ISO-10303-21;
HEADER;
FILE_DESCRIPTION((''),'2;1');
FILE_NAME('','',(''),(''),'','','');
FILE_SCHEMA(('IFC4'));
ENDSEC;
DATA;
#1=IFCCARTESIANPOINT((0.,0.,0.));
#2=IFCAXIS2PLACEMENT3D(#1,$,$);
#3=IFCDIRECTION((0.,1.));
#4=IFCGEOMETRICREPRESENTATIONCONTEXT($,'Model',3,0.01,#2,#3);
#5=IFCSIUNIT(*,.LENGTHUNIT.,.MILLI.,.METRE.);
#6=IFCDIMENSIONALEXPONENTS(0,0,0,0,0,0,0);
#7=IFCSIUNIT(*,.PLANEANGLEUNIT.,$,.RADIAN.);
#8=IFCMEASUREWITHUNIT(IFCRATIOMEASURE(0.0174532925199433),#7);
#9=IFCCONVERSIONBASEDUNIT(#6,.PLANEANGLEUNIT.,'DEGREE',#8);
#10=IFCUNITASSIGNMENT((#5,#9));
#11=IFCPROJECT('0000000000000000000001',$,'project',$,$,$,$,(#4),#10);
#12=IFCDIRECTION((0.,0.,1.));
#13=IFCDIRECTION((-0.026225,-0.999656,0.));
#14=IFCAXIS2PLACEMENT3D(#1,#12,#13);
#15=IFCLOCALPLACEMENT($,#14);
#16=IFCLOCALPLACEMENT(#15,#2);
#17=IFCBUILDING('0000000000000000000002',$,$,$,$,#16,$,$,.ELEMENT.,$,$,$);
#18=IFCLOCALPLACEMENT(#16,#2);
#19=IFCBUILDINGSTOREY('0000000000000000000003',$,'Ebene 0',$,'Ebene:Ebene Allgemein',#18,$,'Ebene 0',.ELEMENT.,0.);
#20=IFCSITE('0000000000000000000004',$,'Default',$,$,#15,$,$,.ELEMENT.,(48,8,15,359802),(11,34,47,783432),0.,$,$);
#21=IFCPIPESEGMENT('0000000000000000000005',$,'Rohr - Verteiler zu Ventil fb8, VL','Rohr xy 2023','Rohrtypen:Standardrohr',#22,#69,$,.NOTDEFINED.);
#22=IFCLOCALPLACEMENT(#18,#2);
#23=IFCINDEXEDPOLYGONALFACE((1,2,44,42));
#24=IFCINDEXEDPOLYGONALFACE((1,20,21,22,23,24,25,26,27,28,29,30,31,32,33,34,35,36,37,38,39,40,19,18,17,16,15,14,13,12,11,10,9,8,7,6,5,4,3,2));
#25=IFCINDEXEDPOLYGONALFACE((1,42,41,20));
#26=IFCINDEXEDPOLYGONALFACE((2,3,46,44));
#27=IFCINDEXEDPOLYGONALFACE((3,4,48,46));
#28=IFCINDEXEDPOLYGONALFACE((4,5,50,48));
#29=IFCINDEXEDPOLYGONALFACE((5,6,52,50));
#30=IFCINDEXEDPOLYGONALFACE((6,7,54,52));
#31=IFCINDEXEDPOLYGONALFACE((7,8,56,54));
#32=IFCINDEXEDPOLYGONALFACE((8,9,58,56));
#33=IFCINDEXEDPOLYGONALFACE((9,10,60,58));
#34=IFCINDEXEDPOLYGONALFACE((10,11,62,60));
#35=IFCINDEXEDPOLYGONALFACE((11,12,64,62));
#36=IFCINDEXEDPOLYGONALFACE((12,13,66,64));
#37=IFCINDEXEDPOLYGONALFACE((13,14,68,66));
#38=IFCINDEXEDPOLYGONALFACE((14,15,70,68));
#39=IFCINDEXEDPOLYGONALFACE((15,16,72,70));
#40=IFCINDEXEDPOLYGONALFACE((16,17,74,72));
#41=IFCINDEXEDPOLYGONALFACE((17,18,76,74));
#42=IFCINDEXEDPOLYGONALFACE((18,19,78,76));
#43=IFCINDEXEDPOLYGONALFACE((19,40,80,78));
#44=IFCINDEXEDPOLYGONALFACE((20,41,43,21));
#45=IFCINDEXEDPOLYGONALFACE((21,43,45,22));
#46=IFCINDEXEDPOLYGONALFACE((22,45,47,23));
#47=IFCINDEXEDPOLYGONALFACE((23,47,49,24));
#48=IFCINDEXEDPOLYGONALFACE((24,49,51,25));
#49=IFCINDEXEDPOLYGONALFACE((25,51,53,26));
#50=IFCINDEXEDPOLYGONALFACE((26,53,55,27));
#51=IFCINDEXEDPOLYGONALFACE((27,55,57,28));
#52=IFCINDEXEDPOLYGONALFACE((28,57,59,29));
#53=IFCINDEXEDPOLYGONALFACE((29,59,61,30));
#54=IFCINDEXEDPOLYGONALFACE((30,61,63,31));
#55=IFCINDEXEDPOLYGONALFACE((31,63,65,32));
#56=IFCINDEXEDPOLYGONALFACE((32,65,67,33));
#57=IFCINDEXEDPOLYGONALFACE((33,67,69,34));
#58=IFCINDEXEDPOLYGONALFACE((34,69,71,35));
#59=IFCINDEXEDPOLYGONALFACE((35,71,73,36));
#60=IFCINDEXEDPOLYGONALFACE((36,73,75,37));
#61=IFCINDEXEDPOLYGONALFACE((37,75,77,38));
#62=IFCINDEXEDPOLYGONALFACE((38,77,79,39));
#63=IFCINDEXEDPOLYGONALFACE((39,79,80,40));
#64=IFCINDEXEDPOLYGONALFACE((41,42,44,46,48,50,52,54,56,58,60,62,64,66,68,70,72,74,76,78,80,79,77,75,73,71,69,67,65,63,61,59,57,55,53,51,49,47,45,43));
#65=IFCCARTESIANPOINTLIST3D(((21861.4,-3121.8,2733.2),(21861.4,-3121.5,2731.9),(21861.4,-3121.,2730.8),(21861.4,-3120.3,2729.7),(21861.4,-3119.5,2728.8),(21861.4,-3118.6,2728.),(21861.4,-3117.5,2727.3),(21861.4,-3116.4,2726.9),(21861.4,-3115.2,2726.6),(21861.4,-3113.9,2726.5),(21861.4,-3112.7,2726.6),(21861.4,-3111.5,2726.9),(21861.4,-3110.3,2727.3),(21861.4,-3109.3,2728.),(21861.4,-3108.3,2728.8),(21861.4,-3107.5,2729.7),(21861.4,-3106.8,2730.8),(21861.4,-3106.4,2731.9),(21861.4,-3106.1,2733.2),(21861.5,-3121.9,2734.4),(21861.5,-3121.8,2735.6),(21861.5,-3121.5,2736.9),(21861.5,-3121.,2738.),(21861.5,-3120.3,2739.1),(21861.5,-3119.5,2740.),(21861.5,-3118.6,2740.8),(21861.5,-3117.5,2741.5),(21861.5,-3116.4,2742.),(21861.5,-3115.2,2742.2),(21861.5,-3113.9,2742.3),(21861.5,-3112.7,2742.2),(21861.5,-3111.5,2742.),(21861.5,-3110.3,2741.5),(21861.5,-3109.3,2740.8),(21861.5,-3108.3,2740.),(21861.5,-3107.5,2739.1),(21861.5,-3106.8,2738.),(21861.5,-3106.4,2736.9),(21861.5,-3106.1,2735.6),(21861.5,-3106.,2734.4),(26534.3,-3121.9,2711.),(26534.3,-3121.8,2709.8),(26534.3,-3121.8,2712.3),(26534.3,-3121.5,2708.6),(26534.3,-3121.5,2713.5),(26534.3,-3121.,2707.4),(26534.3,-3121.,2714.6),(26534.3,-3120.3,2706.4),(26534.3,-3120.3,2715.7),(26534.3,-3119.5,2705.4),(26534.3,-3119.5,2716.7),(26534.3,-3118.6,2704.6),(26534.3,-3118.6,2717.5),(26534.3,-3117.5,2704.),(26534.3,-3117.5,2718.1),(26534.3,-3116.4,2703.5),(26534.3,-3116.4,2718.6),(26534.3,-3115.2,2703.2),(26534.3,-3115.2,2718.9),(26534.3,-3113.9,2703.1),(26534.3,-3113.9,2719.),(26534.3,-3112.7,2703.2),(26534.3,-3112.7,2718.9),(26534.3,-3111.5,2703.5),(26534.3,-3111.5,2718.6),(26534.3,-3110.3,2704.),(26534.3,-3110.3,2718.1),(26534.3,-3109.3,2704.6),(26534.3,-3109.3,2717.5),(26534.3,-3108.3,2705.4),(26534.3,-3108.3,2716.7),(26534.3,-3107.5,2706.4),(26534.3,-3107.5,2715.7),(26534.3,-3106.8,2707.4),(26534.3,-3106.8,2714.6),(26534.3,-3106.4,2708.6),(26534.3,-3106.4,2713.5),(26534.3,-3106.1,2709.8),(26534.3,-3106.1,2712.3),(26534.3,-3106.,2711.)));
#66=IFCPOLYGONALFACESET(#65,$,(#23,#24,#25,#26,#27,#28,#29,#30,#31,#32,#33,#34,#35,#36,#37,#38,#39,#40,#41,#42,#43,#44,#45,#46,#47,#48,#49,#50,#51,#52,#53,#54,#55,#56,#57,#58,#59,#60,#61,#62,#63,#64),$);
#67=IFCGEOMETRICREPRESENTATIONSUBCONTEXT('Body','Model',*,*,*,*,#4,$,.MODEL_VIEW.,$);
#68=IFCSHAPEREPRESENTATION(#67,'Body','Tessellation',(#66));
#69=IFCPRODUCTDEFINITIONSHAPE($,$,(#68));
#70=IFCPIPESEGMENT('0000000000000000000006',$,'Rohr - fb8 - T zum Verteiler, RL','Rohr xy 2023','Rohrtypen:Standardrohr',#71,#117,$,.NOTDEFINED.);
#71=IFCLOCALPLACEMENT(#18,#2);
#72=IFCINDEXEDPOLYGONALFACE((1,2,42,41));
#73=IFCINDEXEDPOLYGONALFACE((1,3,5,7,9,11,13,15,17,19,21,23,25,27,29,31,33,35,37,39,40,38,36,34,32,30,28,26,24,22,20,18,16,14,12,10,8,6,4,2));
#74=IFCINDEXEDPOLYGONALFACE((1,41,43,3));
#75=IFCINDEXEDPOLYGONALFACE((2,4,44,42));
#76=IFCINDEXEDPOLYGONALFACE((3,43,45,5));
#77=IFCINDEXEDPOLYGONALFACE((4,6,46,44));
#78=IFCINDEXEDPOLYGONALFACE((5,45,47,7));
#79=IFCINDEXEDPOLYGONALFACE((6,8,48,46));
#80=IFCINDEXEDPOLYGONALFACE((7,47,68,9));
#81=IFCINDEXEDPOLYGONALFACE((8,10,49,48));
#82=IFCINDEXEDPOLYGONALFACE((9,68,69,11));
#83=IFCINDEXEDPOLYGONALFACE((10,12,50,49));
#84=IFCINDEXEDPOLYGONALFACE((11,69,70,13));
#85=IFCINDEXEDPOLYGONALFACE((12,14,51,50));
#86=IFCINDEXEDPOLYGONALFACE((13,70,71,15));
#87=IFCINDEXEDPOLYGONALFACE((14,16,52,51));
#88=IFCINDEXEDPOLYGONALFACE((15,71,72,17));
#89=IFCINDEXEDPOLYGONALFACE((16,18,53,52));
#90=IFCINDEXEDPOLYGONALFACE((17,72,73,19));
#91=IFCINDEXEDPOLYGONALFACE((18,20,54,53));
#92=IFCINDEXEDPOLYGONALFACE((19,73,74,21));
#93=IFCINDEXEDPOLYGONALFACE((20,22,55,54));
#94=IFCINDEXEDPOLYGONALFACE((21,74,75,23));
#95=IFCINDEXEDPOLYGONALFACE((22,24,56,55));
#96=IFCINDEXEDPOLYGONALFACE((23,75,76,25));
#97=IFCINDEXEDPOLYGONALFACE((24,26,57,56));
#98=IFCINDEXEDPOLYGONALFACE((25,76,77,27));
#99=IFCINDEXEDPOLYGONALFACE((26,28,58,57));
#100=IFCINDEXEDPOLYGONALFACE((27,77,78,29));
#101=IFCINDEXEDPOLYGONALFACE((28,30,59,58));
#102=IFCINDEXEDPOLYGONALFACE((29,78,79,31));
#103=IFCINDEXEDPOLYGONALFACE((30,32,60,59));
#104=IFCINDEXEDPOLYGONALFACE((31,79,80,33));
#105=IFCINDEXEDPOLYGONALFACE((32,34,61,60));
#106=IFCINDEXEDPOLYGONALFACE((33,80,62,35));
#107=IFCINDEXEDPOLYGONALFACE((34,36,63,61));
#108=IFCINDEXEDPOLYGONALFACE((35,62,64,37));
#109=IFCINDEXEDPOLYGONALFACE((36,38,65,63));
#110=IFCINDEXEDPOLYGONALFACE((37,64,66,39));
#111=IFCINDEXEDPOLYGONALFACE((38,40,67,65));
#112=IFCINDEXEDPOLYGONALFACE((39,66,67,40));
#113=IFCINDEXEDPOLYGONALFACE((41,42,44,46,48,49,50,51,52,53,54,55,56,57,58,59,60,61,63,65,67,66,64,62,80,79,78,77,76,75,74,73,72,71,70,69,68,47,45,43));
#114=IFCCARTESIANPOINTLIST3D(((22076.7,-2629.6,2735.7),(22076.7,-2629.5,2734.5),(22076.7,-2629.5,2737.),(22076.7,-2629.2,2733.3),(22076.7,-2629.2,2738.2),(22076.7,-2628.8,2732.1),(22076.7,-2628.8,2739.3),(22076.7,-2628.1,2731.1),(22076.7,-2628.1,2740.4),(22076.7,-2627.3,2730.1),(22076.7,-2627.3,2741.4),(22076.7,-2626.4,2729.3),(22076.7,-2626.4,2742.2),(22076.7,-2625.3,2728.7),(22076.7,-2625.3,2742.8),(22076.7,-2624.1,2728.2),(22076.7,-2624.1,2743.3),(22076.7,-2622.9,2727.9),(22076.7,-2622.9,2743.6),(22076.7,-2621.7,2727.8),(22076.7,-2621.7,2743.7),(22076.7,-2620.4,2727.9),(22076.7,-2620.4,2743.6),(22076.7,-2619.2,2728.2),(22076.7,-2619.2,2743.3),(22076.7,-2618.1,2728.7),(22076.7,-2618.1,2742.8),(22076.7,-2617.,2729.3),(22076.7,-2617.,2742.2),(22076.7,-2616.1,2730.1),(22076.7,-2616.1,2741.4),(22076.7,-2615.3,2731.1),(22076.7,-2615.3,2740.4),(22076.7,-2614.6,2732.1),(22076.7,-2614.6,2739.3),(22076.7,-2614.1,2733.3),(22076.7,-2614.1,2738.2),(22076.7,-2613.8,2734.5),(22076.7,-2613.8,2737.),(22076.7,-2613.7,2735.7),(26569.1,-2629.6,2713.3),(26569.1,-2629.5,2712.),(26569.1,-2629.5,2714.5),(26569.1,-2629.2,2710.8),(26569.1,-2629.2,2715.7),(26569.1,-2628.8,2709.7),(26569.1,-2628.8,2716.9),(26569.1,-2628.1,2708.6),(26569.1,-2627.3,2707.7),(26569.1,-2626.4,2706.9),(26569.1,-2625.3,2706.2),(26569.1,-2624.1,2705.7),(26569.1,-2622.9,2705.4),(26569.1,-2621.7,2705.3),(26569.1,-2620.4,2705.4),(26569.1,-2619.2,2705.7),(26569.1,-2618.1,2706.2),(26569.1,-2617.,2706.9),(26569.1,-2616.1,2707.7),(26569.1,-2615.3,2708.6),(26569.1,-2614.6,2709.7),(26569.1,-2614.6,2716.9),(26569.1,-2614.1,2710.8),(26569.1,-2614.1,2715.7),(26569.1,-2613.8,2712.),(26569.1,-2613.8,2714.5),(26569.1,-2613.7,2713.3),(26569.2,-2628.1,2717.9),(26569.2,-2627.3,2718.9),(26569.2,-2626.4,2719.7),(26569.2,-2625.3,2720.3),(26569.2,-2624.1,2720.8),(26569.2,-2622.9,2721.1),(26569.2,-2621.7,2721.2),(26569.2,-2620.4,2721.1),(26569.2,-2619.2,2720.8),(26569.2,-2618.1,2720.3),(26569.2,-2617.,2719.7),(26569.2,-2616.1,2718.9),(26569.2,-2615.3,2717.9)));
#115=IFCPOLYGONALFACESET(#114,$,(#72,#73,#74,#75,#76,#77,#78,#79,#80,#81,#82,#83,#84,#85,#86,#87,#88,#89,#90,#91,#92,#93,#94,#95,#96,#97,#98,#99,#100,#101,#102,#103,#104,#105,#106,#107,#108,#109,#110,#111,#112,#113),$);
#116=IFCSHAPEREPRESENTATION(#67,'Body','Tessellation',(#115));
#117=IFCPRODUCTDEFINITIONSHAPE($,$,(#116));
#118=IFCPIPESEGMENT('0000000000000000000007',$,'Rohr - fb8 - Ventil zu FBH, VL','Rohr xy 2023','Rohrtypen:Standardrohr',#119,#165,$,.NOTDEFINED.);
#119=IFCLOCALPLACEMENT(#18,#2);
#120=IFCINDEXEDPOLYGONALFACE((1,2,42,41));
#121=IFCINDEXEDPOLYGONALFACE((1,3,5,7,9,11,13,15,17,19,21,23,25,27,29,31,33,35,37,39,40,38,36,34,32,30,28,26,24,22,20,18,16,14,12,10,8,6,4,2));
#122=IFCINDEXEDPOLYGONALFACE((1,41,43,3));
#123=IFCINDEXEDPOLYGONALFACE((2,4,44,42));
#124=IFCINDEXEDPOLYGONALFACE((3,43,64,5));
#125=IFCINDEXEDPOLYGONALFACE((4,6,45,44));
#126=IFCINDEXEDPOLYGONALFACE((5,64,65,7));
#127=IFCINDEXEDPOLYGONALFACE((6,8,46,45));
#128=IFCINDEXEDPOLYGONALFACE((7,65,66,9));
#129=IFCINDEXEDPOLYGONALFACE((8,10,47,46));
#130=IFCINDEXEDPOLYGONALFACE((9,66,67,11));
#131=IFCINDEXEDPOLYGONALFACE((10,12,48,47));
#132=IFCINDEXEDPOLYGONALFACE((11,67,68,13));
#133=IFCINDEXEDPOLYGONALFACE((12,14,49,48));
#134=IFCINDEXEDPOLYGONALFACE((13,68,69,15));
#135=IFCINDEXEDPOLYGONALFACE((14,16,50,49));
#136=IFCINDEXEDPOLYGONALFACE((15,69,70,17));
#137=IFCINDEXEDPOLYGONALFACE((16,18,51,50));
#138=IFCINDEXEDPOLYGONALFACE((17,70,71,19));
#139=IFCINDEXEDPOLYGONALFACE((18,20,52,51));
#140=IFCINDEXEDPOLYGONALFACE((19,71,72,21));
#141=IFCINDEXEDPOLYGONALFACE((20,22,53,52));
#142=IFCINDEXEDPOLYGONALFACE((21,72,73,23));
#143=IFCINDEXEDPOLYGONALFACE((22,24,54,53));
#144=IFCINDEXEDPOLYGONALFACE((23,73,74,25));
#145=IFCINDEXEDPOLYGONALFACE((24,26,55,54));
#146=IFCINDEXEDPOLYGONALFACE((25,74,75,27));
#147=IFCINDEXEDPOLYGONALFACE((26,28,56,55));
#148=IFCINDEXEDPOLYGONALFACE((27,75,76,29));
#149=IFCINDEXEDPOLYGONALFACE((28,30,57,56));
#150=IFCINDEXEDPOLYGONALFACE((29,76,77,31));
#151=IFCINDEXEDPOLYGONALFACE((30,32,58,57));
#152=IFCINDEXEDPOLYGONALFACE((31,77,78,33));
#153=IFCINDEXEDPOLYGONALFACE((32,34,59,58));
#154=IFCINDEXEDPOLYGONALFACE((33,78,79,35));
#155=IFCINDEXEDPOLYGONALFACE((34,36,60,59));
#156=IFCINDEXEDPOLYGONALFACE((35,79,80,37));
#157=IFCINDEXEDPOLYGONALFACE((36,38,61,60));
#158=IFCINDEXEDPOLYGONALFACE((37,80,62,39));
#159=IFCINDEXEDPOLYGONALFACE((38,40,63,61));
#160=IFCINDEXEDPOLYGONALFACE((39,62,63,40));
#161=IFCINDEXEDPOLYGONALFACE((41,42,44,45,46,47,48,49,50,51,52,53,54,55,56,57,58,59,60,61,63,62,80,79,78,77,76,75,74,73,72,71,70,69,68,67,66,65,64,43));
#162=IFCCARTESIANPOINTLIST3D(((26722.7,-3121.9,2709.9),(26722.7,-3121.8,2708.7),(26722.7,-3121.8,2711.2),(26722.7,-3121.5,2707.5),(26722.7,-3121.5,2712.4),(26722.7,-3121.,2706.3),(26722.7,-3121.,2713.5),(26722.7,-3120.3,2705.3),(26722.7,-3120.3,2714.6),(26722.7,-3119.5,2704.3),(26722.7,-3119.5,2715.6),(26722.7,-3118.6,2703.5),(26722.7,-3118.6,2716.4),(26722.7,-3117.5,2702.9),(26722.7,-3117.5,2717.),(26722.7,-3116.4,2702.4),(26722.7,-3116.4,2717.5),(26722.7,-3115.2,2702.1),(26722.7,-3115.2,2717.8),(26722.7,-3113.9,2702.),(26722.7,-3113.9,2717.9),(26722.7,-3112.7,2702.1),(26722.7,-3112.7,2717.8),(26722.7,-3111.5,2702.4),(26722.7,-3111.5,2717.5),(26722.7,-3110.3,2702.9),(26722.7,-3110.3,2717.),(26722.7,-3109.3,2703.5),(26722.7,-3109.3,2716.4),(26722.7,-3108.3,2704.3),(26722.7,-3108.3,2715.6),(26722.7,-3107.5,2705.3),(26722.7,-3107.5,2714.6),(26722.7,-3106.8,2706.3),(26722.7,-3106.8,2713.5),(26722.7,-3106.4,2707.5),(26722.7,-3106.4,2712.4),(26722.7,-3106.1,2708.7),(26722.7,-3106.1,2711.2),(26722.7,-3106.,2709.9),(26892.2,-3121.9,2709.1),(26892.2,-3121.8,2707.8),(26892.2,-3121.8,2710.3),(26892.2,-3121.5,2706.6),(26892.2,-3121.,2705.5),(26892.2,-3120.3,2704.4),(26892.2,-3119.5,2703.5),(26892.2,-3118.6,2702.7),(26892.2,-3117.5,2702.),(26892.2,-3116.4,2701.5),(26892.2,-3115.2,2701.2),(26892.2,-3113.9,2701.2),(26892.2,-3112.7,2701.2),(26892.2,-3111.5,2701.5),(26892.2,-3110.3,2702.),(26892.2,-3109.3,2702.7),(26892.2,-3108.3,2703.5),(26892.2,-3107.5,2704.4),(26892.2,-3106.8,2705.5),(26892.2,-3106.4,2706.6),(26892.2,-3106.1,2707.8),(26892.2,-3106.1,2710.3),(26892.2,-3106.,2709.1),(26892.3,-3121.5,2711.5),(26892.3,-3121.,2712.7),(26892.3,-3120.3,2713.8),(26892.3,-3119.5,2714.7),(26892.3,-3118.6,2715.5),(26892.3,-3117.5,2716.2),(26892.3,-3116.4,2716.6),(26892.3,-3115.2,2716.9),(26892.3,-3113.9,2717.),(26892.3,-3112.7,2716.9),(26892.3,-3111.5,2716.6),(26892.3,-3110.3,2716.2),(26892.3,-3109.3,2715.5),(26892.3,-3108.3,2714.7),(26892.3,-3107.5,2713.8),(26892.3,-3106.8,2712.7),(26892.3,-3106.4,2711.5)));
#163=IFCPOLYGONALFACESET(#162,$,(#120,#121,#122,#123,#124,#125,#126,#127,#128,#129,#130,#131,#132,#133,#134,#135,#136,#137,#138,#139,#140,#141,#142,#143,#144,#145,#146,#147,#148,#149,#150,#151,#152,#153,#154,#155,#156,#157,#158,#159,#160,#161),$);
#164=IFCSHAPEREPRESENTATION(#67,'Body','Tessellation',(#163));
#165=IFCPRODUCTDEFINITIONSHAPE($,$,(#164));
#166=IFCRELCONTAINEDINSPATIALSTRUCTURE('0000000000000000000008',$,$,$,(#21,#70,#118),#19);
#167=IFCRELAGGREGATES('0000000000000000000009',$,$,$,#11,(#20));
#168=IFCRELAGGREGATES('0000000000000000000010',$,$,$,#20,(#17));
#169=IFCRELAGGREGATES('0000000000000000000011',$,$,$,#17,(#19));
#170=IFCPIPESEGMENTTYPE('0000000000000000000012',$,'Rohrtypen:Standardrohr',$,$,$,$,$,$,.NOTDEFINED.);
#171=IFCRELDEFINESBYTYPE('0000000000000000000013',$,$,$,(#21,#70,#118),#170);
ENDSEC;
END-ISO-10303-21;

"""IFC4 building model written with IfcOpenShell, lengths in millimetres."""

from ifc_helpers import new_model, entity, si_unit, converted_unit, direction, frame, origin, place, context, subcontext, project, spatial, indexed_curve, outline, extrude, type_object, element, save


model = new_model("IFC4")

# Units and contexts
model_context = context("Model", 3, precision=0.01, world=origin(), true_north=direction((0.0, 1.0)))
body_context = subcontext(model_context, "Body", "Model", "MODEL_VIEW")
ifc_project = project(units=[si_unit("LENGTHUNIT", "METRE", prefix="MILLI"), converted_unit("PLANEANGLEUNIT", "DEGREE", entity("IfcRatioMeasure", 0.0174532925199433), si_unit("PLANEANGLEUNIT", "RADIAN"), dimensions=[0, 0, 0, 0, 0, 0, 0])], contexts=[model_context])

# Site, building, storey
site_placement = place(None, frame((0.0, 0.0, 0.0), z_axis=(0.0, 0.0, 1.0), x_axis=(-0.026225, -0.999656, 0.0)))
site = spatial("IfcSite", under=ifc_project, at=site_placement, Name="Default", CompositionType="ELEMENT", RefLatitude=(48, 8, 15, 359802), RefLongitude=(11, 34, 47, 783432), RefElevation=0.0)
building_placement = place(site_placement, origin())
building = spatial("IfcBuilding", under=site, at=building_placement, CompositionType="ELEMENT")
storey_placement = place(building_placement, origin())
storey = spatial("IfcBuildingStorey", under=building, at=storey_placement, Name="Ebene 0", ObjectType="Ebene:Ebene Allgemein", LongName="Ebene 0", CompositionType="ELEMENT", Elevation=0.0)

# Pipe segments
pipe_segment_type = type_object("IfcPipeSegmentType", Name="Rohrtypen:Standardrohr", PredefinedType="NOTDEFINED")
pipe_segment_1_placement = place(storey_placement, origin())
element("IfcPipeSegment", 1, at=pipe_segment_1_placement, inside=storey, type_object=pipe_segment_type, Name="Rohr - Verteiler zu Ventil fb8, VL", Description="Rohr xy 2023", ObjectType="Rohrtypen:Standardrohr", PredefinedType="NOTDEFINED", context=body_context, shape_type="SweptSolid", body=[
    extrude(outline(indexed_curve([(7.9, 0.0), (7.8, 1.2), (7.6, 2.5), (7.1, 3.6), (6.4, 4.7), (5.6, 5.6), (4.7, 6.4), (3.6, 7.1), (2.5, 7.6), (1.2, 7.8), (0.0, 7.9), (-1.2, 7.8), (-2.5, 7.6), (-3.6, 7.1), (-4.7, 6.4), (-5.6, 5.6), (-6.4, 4.7), (-7.1, 3.6), (-7.6, 2.5), (-7.8, 1.2), (-7.9, 0.0), (-7.8, -1.2), (-7.6, -2.5), (-7.1, -3.6), (-6.4, -4.7), (-5.6, -5.6), (-4.7, -6.4), (-3.6, -7.1), (-2.5, -7.6), (-1.2, -7.8), (0.0, -7.9), (1.2, -7.8), (2.5, -7.6), (3.6, -7.1), (4.7, -6.4), (5.6, -5.6), (6.4, -4.7), (7.1, -3.6), (7.6, -2.5), (7.8, -1.2), (7.9, 0.0)], self_intersect=False)), frame((26534.3, -3113.9, 2711.0), z_axis=(-0.999988, 0.0, 0.005), x_axis=(0.0, 1.0, 0.0)), (0.0, 0.0, 1.0), 4672.9),
])
pipe_segment_2_placement = place(storey_placement, origin())
element("IfcPipeSegment", 2, at=pipe_segment_2_placement, inside=storey, type_object=pipe_segment_type, Name="Rohr - fb8 - T zum Verteiler, RL", Description="Rohr xy 2023", ObjectType="Rohrtypen:Standardrohr", PredefinedType="NOTDEFINED", context=body_context, shape_type="SweptSolid", body=[
    extrude(outline(indexed_curve([(7.9, 0.0), (7.8, 1.2), (7.6, 2.5), (7.1, 3.6), (6.4, 4.7), (5.6, 5.6), (4.7, 6.4), (3.6, 7.1), (2.5, 7.6), (1.2, 7.8), (0.0, 7.9), (-1.2, 7.8), (-2.5, 7.6), (-3.6, 7.1), (-4.7, 6.4), (-5.6, 5.6), (-6.4, 4.7), (-7.1, 3.6), (-7.6, 2.5), (-7.8, 1.2), (-7.9, 0.0), (-7.8, -1.2), (-7.6, -2.5), (-7.1, -3.6), (-6.4, -4.7), (-5.6, -5.6), (-4.7, -6.4), (-3.6, -7.1), (-2.5, -7.6), (-1.2, -7.8), (0.0, -7.9), (1.2, -7.8), (2.5, -7.6), (3.6, -7.1), (4.7, -6.4), (5.6, -5.6), (6.4, -4.7), (7.1, -3.6), (7.6, -2.5), (7.8, -1.2), (7.9, 0.0)], self_intersect=False)), frame((26569.1, -2621.7, 2713.3), z_axis=(-0.999988, 0.0, 0.005), x_axis=(0.0, 1.0, 0.0)), (0.0, 0.0, 1.0), 4492.5),
])
pipe_segment_3_placement = place(storey_placement, origin())
element("IfcPipeSegment", 3, at=pipe_segment_3_placement, inside=storey, type_object=pipe_segment_type, Name="Rohr - fb8 - Ventil zu FBH, VL", Description="Rohr xy 2023", ObjectType="Rohrtypen:Standardrohr", PredefinedType="NOTDEFINED", context=body_context, shape_type="SweptSolid", body=[
    extrude(outline(indexed_curve([(7.9, 0.0), (7.8, 1.2), (7.6, 2.5), (7.1, 3.6), (6.4, 4.7), (5.6, 5.6), (4.7, 6.4), (3.6, 7.1), (2.5, 7.6), (1.2, 7.8), (0.0, 7.9), (-1.2, 7.8), (-2.5, 7.6), (-3.6, 7.1), (-4.7, 6.4), (-5.6, 5.6), (-6.4, 4.7), (-7.1, 3.6), (-7.6, 2.5), (-7.8, 1.2), (-7.9, 0.0), (-7.8, -1.2), (-7.6, -2.5), (-7.1, -3.6), (-6.4, -4.7), (-5.6, -5.6), (-4.7, -6.4), (-3.6, -7.1), (-2.5, -7.6), (-1.2, -7.8), (0.0, -7.9), (1.2, -7.8), (2.5, -7.6), (3.6, -7.1), (4.7, -6.4), (5.6, -5.6), (6.4, -4.7), (7.1, -3.6), (7.6, -2.5), (7.8, -1.2), (7.9, 0.0)], self_intersect=False)), frame((26722.7, -3113.9, 2709.9), z_axis=(0.999988, 0.0, -0.005), x_axis=(0.0, 1.0, 0.0)), (0.0, 0.0, 1.0), 169.5),
])

save(model, "model.ifc")
